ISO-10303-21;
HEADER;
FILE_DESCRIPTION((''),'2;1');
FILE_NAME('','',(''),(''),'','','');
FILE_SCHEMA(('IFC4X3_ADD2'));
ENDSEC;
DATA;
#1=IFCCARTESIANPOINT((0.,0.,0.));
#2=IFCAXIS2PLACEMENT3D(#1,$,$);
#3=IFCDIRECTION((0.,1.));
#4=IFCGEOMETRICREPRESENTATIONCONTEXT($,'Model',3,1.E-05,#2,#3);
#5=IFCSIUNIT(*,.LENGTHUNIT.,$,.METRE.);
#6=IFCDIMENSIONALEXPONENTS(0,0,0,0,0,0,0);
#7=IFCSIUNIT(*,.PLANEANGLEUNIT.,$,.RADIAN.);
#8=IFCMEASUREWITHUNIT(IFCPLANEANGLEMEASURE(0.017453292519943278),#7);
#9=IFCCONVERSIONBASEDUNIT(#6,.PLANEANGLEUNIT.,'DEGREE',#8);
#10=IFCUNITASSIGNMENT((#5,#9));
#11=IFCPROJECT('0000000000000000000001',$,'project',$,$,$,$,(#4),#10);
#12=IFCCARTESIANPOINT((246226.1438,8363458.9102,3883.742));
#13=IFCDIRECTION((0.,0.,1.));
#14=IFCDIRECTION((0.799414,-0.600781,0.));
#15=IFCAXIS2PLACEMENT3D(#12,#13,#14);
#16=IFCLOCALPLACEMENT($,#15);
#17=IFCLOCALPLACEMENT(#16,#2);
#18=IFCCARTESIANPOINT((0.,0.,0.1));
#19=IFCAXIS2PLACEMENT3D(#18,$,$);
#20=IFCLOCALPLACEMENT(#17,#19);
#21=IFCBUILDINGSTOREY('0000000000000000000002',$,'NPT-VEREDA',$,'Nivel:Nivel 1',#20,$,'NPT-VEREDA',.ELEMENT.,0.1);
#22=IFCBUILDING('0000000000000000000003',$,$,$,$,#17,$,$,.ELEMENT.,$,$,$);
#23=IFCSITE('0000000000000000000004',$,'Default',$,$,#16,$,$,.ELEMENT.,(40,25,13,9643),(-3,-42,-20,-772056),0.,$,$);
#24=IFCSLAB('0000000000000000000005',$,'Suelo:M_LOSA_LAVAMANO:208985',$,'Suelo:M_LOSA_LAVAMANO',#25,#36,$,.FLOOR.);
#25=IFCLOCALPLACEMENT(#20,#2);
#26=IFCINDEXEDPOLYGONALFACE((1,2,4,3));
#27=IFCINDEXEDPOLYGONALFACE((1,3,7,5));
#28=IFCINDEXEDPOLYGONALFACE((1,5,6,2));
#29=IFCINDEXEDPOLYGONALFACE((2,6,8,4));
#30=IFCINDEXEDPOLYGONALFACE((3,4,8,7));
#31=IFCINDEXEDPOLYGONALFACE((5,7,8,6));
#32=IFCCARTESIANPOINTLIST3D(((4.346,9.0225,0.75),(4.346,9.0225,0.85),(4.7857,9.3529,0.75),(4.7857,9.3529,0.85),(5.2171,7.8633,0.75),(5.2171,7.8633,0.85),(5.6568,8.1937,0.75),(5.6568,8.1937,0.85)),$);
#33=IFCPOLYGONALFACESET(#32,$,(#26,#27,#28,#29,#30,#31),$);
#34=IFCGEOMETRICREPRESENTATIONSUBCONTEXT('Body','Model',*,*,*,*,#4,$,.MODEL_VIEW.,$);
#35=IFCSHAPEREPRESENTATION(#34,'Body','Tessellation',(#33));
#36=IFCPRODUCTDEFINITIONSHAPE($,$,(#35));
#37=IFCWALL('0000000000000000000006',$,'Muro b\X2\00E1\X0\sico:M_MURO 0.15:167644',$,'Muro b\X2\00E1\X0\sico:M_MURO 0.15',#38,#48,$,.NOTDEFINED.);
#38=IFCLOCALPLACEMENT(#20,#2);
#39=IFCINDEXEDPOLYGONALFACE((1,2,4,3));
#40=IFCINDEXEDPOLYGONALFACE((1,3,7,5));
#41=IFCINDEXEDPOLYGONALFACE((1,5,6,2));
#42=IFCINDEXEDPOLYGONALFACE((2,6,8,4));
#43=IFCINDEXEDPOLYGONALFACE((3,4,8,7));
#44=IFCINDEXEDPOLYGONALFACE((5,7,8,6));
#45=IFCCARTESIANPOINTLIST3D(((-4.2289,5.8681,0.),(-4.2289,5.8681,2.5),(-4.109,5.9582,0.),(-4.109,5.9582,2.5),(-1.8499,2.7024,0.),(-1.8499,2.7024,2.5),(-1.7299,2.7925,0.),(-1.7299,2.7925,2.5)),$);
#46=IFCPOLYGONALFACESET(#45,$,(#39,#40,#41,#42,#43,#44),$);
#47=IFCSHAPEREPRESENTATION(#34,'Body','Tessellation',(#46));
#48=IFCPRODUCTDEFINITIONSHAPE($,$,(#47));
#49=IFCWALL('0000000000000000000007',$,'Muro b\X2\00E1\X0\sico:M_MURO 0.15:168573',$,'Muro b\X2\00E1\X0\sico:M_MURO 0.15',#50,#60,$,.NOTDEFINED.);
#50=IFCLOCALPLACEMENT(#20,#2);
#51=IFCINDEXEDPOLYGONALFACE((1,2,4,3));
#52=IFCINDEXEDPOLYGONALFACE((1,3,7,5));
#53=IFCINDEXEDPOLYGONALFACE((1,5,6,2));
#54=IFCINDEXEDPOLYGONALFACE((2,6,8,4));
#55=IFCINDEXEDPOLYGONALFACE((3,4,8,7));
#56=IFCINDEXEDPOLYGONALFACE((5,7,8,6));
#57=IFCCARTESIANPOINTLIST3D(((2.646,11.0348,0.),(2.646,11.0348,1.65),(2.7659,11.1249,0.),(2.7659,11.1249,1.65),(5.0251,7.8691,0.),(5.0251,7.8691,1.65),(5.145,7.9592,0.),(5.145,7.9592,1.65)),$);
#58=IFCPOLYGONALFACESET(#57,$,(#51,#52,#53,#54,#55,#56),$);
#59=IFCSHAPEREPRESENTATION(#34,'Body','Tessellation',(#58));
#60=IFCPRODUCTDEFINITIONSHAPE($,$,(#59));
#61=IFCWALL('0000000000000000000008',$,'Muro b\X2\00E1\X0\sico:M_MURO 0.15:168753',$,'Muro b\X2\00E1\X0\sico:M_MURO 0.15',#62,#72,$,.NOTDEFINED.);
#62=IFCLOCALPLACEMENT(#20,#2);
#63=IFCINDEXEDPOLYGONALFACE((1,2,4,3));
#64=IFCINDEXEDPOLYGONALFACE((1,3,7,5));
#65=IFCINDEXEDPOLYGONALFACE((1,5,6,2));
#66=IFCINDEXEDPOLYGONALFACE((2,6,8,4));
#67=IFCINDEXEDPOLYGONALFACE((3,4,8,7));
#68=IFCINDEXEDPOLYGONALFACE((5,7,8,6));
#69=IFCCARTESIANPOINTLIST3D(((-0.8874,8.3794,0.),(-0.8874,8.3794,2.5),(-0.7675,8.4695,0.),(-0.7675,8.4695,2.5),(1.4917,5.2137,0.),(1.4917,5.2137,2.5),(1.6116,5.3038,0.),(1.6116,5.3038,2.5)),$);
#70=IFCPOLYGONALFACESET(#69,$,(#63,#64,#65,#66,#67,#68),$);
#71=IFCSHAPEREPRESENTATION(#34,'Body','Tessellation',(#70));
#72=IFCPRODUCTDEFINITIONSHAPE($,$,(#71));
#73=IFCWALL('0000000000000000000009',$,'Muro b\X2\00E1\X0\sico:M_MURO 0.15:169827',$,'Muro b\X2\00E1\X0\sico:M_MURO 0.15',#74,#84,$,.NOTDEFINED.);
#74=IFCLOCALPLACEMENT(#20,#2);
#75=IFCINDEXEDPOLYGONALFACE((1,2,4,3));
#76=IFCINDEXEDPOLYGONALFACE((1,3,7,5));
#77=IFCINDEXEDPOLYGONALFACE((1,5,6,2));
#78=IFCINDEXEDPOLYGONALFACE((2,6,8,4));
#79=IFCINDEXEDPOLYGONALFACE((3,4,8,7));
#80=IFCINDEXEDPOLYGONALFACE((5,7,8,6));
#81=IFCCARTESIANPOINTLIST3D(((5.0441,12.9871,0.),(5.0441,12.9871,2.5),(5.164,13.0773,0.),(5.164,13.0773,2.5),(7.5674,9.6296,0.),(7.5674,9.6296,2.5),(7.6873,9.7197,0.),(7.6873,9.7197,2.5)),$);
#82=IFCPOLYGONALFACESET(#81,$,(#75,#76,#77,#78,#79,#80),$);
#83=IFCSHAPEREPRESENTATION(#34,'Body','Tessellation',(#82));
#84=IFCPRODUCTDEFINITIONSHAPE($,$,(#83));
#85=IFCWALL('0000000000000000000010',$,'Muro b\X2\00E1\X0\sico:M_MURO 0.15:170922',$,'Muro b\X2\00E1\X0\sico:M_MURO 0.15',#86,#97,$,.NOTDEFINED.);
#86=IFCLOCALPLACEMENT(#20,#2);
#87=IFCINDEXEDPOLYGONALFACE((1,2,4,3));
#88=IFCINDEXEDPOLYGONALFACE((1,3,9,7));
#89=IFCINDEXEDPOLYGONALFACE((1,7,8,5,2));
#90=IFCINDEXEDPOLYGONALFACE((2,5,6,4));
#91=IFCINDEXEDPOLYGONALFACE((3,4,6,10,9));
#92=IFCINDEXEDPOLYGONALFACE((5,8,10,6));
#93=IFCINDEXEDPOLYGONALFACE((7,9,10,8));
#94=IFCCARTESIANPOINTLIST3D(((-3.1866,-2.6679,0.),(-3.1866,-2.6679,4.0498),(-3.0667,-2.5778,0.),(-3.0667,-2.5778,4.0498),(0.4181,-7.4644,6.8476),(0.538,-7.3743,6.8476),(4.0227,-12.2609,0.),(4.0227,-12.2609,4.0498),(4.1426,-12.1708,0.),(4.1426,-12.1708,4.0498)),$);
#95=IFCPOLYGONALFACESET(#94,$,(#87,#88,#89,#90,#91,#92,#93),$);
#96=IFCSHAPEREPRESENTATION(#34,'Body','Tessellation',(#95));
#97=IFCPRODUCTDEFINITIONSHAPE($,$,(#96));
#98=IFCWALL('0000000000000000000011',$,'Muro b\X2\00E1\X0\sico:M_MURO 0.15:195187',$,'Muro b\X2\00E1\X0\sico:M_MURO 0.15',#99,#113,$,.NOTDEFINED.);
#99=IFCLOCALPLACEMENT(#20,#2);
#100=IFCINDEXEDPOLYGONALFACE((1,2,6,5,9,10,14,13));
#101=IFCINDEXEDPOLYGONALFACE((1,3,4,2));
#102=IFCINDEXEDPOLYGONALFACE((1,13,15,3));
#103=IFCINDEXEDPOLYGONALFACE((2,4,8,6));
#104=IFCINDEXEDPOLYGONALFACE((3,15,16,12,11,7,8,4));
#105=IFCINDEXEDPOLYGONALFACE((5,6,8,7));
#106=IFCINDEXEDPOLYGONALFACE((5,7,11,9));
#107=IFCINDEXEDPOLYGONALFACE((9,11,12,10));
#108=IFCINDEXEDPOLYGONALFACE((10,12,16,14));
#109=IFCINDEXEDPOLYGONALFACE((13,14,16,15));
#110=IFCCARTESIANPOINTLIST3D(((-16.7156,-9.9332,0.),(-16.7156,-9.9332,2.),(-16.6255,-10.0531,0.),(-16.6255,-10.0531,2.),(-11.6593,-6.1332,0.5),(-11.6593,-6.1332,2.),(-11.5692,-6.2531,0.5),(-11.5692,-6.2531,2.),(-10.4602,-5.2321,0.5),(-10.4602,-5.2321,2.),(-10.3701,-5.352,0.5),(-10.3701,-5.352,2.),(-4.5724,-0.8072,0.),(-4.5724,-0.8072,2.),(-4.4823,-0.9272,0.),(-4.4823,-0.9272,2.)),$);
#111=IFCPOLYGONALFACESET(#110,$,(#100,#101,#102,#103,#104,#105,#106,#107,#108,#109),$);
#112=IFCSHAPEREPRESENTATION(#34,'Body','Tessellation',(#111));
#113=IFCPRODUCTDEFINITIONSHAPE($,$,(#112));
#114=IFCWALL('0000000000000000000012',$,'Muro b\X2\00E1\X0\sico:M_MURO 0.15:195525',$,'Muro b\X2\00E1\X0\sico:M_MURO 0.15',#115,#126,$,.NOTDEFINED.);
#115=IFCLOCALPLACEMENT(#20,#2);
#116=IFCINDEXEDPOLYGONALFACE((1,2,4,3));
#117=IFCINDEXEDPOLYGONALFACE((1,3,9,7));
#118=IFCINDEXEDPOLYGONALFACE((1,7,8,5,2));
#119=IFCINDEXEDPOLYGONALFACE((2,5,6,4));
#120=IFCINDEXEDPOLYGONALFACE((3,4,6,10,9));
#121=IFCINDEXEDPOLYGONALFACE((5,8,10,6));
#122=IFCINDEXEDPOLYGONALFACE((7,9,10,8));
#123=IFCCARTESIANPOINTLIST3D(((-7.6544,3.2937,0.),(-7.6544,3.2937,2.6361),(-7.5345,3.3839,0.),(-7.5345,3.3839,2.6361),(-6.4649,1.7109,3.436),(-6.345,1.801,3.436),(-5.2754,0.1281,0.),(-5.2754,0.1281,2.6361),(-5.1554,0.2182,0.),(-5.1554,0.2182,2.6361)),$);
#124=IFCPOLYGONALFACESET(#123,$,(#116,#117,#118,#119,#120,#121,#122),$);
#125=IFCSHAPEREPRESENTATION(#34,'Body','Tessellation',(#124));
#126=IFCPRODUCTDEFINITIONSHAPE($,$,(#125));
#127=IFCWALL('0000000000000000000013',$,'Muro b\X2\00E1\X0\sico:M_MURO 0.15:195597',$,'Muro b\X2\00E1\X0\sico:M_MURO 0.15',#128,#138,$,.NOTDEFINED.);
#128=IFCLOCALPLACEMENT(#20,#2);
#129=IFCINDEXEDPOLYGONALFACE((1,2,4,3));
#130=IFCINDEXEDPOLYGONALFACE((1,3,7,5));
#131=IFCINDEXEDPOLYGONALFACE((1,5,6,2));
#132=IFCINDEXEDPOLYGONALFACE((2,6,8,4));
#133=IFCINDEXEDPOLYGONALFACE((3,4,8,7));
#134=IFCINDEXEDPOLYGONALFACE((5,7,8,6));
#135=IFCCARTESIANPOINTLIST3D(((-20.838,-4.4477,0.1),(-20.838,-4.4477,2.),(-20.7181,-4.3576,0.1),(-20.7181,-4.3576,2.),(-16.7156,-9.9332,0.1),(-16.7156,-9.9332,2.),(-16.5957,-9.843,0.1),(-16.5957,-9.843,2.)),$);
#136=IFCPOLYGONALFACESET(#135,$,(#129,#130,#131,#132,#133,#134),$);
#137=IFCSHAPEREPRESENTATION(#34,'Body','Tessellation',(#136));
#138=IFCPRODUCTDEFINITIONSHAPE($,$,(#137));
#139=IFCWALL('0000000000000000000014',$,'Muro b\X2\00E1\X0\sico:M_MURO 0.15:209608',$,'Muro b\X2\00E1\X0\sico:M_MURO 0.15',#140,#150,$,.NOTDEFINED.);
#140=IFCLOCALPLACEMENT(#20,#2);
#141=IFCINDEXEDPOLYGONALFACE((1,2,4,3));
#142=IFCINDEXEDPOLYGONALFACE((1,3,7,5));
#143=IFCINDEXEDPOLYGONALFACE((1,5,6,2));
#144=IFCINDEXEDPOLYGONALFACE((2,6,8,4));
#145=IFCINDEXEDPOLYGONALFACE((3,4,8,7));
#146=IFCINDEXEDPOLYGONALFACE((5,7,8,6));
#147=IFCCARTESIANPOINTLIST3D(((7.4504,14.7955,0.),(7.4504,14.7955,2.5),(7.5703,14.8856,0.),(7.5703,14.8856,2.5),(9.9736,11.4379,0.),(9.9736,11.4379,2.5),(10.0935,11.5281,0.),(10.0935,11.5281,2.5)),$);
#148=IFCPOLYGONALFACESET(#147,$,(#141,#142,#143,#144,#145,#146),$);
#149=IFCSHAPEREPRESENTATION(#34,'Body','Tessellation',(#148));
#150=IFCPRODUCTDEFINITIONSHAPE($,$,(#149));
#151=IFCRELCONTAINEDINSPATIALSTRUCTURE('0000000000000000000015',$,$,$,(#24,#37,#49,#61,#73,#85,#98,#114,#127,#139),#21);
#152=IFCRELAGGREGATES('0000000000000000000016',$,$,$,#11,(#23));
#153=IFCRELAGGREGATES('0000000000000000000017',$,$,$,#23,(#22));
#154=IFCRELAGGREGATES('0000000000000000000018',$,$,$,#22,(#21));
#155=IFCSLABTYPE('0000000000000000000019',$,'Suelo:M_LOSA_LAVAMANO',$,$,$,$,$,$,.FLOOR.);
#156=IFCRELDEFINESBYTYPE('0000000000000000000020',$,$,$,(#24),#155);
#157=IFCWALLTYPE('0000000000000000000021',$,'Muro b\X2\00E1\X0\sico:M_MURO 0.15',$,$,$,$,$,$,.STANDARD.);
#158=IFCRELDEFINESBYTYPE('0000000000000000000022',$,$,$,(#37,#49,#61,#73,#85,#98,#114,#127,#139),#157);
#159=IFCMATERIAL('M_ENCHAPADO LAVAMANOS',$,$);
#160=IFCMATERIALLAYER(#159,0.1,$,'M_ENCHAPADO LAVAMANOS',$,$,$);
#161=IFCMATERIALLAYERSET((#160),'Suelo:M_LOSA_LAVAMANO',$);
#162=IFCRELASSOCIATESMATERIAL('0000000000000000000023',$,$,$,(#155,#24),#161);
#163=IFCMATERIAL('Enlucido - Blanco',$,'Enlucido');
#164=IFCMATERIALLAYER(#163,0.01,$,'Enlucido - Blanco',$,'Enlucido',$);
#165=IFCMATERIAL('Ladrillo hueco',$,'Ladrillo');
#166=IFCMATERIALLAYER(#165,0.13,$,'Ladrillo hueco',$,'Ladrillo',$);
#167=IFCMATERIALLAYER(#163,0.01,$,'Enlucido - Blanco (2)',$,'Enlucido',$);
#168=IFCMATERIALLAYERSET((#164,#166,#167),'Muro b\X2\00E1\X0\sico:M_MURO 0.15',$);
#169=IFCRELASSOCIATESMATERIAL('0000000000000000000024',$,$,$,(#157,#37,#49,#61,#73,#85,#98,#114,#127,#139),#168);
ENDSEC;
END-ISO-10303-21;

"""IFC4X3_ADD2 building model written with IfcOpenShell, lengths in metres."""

from ifc_helpers import new_model, entity, si_unit, converted_unit, direction, frame, frame_2d, origin, place, context, subcontext, project, spatial, polyline, rectangle, extrude, clip, bounded_halfspace, material, layer, layer_set, layer_usage, type_object, element, save


model = new_model("IFC4X3_ADD2")

# Units and contexts
model_context = context("Model", 3, precision=1e-05, world=origin(), true_north=direction((0.0, 1.0)))
body_context = subcontext(model_context, "Body", "Model", "MODEL_VIEW")
ifc_project = project(units=[si_unit("LENGTHUNIT", "METRE"), converted_unit("PLANEANGLEUNIT", "DEGREE", entity("IfcPlaneAngleMeasure", 0.017453292519943278), si_unit("PLANEANGLEUNIT", "RADIAN"), dimensions=[0, 0, 0, 0, 0, 0, 0])], contexts=[model_context])

# Site, building, storey
site_placement = place(None, frame((246226.1438, 8363458.9102, 3883.742), z_axis=(0.0, 0.0, 1.0), x_axis=(0.799414, -0.600781, 0.0)))
site = spatial("IfcSite", under=ifc_project, at=site_placement, Name="Default", CompositionType="ELEMENT", RefLatitude=(40, 25, 13, 9643), RefLongitude=(-3, -42, -20, -772056), RefElevation=0.0)
building_placement = place(site_placement, origin())
building = spatial("IfcBuilding", under=site, at=building_placement, CompositionType="ELEMENT")
storey_placement = place(building_placement, frame((0.0, 0.0, 0.1)))
storey = spatial("IfcBuildingStorey", under=building, at=storey_placement, Name="NPT-VEREDA", ObjectType="Nivel:Nivel 1", LongName="NPT-VEREDA", CompositionType="ELEMENT", Elevation=0.1)

# Slab
ifc_material_1 = material(Name="M_ENCHAPADO LAVAMANOS")
ifc_layer_1 = layer(ifc_material_1, 0.1, Name="M_ENCHAPADO LAVAMANOS")
ifc_layer_set_1 = layer_set([ifc_layer_1], Name="Suelo:M_LOSA_LAVAMANO")
ifc_layer_usage_1 = layer_usage(ifc_layer_set_1, "AXIS3", "POSITIVE", 0.0)
slab_type = type_object("IfcSlabType", Name="Suelo:M_LOSA_LAVAMANO", PredefinedType="FLOOR", material=ifc_layer_set_1)
slab_1_placement = place(storey_placement, origin())
element("IfcSlab", 1, at=slab_1_placement, inside=storey, type_object=slab_type, material=ifc_layer_usage_1, Name="Suelo:M_LOSA_LAVAMANO:208985", ObjectType="Suelo:M_LOSA_LAVAMANO", PredefinedType="FLOOR", context=body_context, shape_type="SweptSolid", body=[
    extrude(rectangle(XDim=0.55, YDim=1.45, at=frame_2d((0.0, 0.0), x_axis=(1.0, 0.0))), frame((5.0014, 8.6081, 0.85), z_axis=(0.0, 0.0, -1.0), x_axis=(-0.799414, -0.60078, 0.0)), (0.0, 0.0, 1.0), 0.1),
])

# Shared definitions
ifc_material_2 = material(Name="Enlucido - Blanco", Category="Enlucido")
ifc_layer_2 = layer(ifc_material_2, 0.01, Name="Enlucido - Blanco", Category="Enlucido")
ifc_material_3 = material(Name="Ladrillo hueco", Category="Ladrillo")
ifc_layer_3 = layer(ifc_material_3, 0.13, Name="Ladrillo hueco", Category="Ladrillo")
ifc_layer_4 = layer(ifc_material_2, 0.01, Name="Enlucido - Blanco (2)", Category="Enlucido")
ifc_layer_set_2 = layer_set([ifc_layer_2, ifc_layer_3, ifc_layer_4], Name="Muro básico:M_MURO 0.15")
wall_type_1 = type_object("IfcWallType", Name="Muro básico:M_MURO 0.15", PredefinedType="STANDARD", material=ifc_layer_set_2)

# Walls
wall_1_placement = place(storey_placement, frame((-4.169, 5.9131, 0.0), z_axis=(0.0, 0.0, 1.0), x_axis=(0.60078, -0.799414, 0.0)))
element("IfcWall", 2, at=wall_1_placement, inside=storey, type_object=wall_type_1, material=ifc_layer_set_2, Name="Muro básico:M_MURO 0.15:167644", ObjectType="Muro básico:M_MURO 0.15", PredefinedType="NOTDEFINED", context=body_context, shape_type="SweptSolid", body=[
    extrude(rectangle(XDim=3.96, YDim=0.15, at=frame_2d((1.98, 0.0), x_axis=(-1.0, 0.0))), origin(), (0.0, 0.0, 1.0), 2.5),
])
wall_2_placement = place(storey_placement, frame((2.706, 11.0799, 0.0), z_axis=(0.0, 0.0, 1.0), x_axis=(0.60078, -0.799414, 0.0)))
element("IfcWall", 3, at=wall_2_placement, inside=storey, type_object=wall_type_1, material=ifc_layer_set_2, Name="Muro básico:M_MURO 0.15:168573", ObjectType="Muro básico:M_MURO 0.15", PredefinedType="NOTDEFINED", context=body_context, shape_type="SweptSolid", body=[
    extrude(rectangle(XDim=3.96, YDim=0.15, at=frame_2d((1.98, 0.0), x_axis=(-1.0, 0.0))), origin(), (0.0, 0.0, 1.0), 1.65),
])
wall_3_placement = place(storey_placement, frame((-0.8274, 8.4244, 0.0), z_axis=(0.0, 0.0, 1.0), x_axis=(0.60078, -0.799414, 0.0)))
element("IfcWall", 4, at=wall_3_placement, inside=storey, type_object=wall_type_1, material=ifc_layer_set_2, Name="Muro básico:M_MURO 0.15:168753", ObjectType="Muro básico:M_MURO 0.15", PredefinedType="NOTDEFINED", context=body_context, shape_type="SweptSolid", body=[
    extrude(rectangle(XDim=3.96, YDim=0.15, at=frame_2d((1.98, 0.0), x_axis=(-1.0, 0.0))), origin(), (0.0, 0.0, 1.0), 2.5),
])
wall_4_placement = place(storey_placement, frame((5.1041, 13.0322, 0.0), z_axis=(0.0, 0.0, 1.0), x_axis=(0.60078, -0.799414, 0.0)))
element("IfcWall", 5, at=wall_4_placement, inside=storey, type_object=wall_type_1, material=ifc_layer_set_2, Name="Muro básico:M_MURO 0.15:169827", ObjectType="Muro básico:M_MURO 0.15", PredefinedType="NOTDEFINED", context=body_context, shape_type="SweptSolid", body=[
    extrude(rectangle(XDim=4.2, YDim=0.15, at=frame_2d((2.1, 0.0), x_axis=(-1.0, 0.0))), origin(), (0.0, 0.0, 1.0), 2.5),
])
wall_5_placement = place(storey_placement, frame((-3.1267, -2.6228, 0.0), z_axis=(0.0, 0.0, 1.0), x_axis=(0.60078, -0.799414, 0.0)))
element("IfcWall", 6, at=wall_5_placement, inside=storey, type_object=wall_type_1, material=ifc_layer_set_2, Name="Muro básico:M_MURO 0.15:170922", ObjectType="Muro básico:M_MURO 0.15", PredefinedType="NOTDEFINED", context=body_context, shape_type="Clipping", body=[
    clip(clip(extrude(rectangle(XDim=12.0, YDim=0.15, at=frame_2d((6.0, 0.0), x_axis=(-1.0, 0.0))), origin(), (0.0, 0.0, 1.0), 6.8476), bounded_halfspace(frame((0.0, -0.075, 4.0498), z_axis=(0.422618, 0.0, -0.906308), x_axis=(0.0, 1.0, 0.0)), True, frame((0.0, -0.075, 4.0498)), polyline([(0.0, 0.0), (6.0, 0.0), (6.0, 0.15), (0.0, 0.15), (0.0, 0.0)]))), bounded_halfspace(frame((6.0, -0.075, 6.8476), z_axis=(-0.422618, 0.0, -0.906308), x_axis=(0.0, 1.0, 0.0)), True, frame((6.0, -0.075, 6.8476)), polyline([(0.0, 0.0), (6.0, 0.0), (6.0, 0.15), (0.0, 0.15), (0.0, 0.0)]))),
])

# Wall, opening
wall_6_placement = place(storey_placement, frame((-4.5274, -0.8672, 0.0), z_axis=(0.0, 0.0, 1.0), x_axis=(-0.799414, -0.60078, 0.0)))
wall_6 = element("IfcWall", 7, at=wall_6_placement, inside=storey, type_object=wall_type_1, material=ifc_layer_set_2, Name="Muro básico:M_MURO 0.15:195187", ObjectType="Muro básico:M_MURO 0.15", PredefinedType="NOTDEFINED", context=body_context, shape_type="SweptSolid", body=[
    extrude(rectangle(XDim=15.1901, YDim=0.15, at=frame_2d((7.595, 0.0), x_axis=(-1.0, 0.0))), origin(), (0.0, 0.0, 1.0), 2.0),
])
opening_1_placement = place(wall_6_placement, frame((7.3651, -0.075, 0.5)))
element("IfcOpeningElement", 8, at=opening_1_placement, cuts=wall_6, PredefinedType="OPENING", context=body_context, shape_type="SweptSolid", body=[
    extrude(rectangle(XDim=2.1, YDim=1.5, at=frame_2d((1.05, 0.75), x_axis=(1.0, 0.0))), frame((0.0, 0.0, 0.0), z_axis=(0.0, 1.0, 0.0), x_axis=(0.0, 0.0, 1.0)), (0.0, 0.0, 1.0), 0.15),
])

# Walls
wall_7_placement = place(storey_placement, frame((-5.2154, 0.1731, 0.0), z_axis=(0.0, 0.0, 1.0), x_axis=(-0.60078, 0.799414, 0.0)))
element("IfcWall", 9, at=wall_7_placement, inside=storey, type_object=wall_type_1, material=ifc_layer_set_2, Name="Muro básico:M_MURO 0.15:195525", ObjectType="Muro básico:M_MURO 0.15", PredefinedType="NOTDEFINED", context=body_context, shape_type="Clipping", body=[
    clip(clip(extrude(rectangle(XDim=3.96, YDim=0.15, at=frame_2d((1.98, 0.0), x_axis=(-1.0, 0.0))), origin(), (0.0, 0.0, 1.0), 3.436), bounded_halfspace(frame((0.0, -0.075, 2.6361), z_axis=(0.374607, 0.0, -0.927184), x_axis=(0.0, 1.0, 0.0)), True, frame((0.0, -0.075, 2.6361)), polyline([(0.0, 0.0), (1.98, 0.0), (1.98, 0.15), (0.0, 0.15), (0.0, 0.0)]))), bounded_halfspace(frame((1.98, -0.075, 3.436), z_axis=(-0.374607, 0.0, -0.927184), x_axis=(0.0, 1.0, 0.0)), True, frame((1.98, -0.075, 3.436)), polyline([(0.0, 0.0), (1.98, 0.0), (1.98, 0.15), (0.0, 0.15), (0.0, 0.0)]))),
])
wall_8_placement = place(storey_placement, frame((-16.6557, -9.8881, 0.1), z_axis=(0.0, 0.0, 1.0), x_axis=(-0.60078, 0.799414, 0.0)))
element("IfcWall", 10, at=wall_8_placement, inside=storey, type_object=wall_type_1, material=ifc_layer_set_2, Name="Muro básico:M_MURO 0.15:195597", ObjectType="Muro básico:M_MURO 0.15", PredefinedType="NOTDEFINED", context=body_context, shape_type="SweptSolid", body=[
    extrude(rectangle(XDim=6.8618, YDim=0.15, at=frame_2d((3.4309, 0.0), x_axis=(-1.0, 0.0))), origin(), (0.0, 0.0, 1.0), 1.9),
])
wall_9_placement = place(storey_placement, frame((10.0336, 11.483, 0.0), z_axis=(0.0, 0.0, 1.0), x_axis=(-0.60078, 0.799414, 0.0)))
element("IfcWall", 11, at=wall_9_placement, inside=storey, type_object=wall_type_1, material=ifc_layer_set_2, Name="Muro básico:M_MURO 0.15:209608", ObjectType="Muro básico:M_MURO 0.15", PredefinedType="NOTDEFINED", context=body_context, shape_type="SweptSolid", body=[
    extrude(rectangle(XDim=4.2, YDim=0.15, at=frame_2d((2.1, 0.0), x_axis=(-1.0, 0.0))), origin(), (0.0, 0.0, 1.0), 2.5),
])

save(model, "model.ifc")
